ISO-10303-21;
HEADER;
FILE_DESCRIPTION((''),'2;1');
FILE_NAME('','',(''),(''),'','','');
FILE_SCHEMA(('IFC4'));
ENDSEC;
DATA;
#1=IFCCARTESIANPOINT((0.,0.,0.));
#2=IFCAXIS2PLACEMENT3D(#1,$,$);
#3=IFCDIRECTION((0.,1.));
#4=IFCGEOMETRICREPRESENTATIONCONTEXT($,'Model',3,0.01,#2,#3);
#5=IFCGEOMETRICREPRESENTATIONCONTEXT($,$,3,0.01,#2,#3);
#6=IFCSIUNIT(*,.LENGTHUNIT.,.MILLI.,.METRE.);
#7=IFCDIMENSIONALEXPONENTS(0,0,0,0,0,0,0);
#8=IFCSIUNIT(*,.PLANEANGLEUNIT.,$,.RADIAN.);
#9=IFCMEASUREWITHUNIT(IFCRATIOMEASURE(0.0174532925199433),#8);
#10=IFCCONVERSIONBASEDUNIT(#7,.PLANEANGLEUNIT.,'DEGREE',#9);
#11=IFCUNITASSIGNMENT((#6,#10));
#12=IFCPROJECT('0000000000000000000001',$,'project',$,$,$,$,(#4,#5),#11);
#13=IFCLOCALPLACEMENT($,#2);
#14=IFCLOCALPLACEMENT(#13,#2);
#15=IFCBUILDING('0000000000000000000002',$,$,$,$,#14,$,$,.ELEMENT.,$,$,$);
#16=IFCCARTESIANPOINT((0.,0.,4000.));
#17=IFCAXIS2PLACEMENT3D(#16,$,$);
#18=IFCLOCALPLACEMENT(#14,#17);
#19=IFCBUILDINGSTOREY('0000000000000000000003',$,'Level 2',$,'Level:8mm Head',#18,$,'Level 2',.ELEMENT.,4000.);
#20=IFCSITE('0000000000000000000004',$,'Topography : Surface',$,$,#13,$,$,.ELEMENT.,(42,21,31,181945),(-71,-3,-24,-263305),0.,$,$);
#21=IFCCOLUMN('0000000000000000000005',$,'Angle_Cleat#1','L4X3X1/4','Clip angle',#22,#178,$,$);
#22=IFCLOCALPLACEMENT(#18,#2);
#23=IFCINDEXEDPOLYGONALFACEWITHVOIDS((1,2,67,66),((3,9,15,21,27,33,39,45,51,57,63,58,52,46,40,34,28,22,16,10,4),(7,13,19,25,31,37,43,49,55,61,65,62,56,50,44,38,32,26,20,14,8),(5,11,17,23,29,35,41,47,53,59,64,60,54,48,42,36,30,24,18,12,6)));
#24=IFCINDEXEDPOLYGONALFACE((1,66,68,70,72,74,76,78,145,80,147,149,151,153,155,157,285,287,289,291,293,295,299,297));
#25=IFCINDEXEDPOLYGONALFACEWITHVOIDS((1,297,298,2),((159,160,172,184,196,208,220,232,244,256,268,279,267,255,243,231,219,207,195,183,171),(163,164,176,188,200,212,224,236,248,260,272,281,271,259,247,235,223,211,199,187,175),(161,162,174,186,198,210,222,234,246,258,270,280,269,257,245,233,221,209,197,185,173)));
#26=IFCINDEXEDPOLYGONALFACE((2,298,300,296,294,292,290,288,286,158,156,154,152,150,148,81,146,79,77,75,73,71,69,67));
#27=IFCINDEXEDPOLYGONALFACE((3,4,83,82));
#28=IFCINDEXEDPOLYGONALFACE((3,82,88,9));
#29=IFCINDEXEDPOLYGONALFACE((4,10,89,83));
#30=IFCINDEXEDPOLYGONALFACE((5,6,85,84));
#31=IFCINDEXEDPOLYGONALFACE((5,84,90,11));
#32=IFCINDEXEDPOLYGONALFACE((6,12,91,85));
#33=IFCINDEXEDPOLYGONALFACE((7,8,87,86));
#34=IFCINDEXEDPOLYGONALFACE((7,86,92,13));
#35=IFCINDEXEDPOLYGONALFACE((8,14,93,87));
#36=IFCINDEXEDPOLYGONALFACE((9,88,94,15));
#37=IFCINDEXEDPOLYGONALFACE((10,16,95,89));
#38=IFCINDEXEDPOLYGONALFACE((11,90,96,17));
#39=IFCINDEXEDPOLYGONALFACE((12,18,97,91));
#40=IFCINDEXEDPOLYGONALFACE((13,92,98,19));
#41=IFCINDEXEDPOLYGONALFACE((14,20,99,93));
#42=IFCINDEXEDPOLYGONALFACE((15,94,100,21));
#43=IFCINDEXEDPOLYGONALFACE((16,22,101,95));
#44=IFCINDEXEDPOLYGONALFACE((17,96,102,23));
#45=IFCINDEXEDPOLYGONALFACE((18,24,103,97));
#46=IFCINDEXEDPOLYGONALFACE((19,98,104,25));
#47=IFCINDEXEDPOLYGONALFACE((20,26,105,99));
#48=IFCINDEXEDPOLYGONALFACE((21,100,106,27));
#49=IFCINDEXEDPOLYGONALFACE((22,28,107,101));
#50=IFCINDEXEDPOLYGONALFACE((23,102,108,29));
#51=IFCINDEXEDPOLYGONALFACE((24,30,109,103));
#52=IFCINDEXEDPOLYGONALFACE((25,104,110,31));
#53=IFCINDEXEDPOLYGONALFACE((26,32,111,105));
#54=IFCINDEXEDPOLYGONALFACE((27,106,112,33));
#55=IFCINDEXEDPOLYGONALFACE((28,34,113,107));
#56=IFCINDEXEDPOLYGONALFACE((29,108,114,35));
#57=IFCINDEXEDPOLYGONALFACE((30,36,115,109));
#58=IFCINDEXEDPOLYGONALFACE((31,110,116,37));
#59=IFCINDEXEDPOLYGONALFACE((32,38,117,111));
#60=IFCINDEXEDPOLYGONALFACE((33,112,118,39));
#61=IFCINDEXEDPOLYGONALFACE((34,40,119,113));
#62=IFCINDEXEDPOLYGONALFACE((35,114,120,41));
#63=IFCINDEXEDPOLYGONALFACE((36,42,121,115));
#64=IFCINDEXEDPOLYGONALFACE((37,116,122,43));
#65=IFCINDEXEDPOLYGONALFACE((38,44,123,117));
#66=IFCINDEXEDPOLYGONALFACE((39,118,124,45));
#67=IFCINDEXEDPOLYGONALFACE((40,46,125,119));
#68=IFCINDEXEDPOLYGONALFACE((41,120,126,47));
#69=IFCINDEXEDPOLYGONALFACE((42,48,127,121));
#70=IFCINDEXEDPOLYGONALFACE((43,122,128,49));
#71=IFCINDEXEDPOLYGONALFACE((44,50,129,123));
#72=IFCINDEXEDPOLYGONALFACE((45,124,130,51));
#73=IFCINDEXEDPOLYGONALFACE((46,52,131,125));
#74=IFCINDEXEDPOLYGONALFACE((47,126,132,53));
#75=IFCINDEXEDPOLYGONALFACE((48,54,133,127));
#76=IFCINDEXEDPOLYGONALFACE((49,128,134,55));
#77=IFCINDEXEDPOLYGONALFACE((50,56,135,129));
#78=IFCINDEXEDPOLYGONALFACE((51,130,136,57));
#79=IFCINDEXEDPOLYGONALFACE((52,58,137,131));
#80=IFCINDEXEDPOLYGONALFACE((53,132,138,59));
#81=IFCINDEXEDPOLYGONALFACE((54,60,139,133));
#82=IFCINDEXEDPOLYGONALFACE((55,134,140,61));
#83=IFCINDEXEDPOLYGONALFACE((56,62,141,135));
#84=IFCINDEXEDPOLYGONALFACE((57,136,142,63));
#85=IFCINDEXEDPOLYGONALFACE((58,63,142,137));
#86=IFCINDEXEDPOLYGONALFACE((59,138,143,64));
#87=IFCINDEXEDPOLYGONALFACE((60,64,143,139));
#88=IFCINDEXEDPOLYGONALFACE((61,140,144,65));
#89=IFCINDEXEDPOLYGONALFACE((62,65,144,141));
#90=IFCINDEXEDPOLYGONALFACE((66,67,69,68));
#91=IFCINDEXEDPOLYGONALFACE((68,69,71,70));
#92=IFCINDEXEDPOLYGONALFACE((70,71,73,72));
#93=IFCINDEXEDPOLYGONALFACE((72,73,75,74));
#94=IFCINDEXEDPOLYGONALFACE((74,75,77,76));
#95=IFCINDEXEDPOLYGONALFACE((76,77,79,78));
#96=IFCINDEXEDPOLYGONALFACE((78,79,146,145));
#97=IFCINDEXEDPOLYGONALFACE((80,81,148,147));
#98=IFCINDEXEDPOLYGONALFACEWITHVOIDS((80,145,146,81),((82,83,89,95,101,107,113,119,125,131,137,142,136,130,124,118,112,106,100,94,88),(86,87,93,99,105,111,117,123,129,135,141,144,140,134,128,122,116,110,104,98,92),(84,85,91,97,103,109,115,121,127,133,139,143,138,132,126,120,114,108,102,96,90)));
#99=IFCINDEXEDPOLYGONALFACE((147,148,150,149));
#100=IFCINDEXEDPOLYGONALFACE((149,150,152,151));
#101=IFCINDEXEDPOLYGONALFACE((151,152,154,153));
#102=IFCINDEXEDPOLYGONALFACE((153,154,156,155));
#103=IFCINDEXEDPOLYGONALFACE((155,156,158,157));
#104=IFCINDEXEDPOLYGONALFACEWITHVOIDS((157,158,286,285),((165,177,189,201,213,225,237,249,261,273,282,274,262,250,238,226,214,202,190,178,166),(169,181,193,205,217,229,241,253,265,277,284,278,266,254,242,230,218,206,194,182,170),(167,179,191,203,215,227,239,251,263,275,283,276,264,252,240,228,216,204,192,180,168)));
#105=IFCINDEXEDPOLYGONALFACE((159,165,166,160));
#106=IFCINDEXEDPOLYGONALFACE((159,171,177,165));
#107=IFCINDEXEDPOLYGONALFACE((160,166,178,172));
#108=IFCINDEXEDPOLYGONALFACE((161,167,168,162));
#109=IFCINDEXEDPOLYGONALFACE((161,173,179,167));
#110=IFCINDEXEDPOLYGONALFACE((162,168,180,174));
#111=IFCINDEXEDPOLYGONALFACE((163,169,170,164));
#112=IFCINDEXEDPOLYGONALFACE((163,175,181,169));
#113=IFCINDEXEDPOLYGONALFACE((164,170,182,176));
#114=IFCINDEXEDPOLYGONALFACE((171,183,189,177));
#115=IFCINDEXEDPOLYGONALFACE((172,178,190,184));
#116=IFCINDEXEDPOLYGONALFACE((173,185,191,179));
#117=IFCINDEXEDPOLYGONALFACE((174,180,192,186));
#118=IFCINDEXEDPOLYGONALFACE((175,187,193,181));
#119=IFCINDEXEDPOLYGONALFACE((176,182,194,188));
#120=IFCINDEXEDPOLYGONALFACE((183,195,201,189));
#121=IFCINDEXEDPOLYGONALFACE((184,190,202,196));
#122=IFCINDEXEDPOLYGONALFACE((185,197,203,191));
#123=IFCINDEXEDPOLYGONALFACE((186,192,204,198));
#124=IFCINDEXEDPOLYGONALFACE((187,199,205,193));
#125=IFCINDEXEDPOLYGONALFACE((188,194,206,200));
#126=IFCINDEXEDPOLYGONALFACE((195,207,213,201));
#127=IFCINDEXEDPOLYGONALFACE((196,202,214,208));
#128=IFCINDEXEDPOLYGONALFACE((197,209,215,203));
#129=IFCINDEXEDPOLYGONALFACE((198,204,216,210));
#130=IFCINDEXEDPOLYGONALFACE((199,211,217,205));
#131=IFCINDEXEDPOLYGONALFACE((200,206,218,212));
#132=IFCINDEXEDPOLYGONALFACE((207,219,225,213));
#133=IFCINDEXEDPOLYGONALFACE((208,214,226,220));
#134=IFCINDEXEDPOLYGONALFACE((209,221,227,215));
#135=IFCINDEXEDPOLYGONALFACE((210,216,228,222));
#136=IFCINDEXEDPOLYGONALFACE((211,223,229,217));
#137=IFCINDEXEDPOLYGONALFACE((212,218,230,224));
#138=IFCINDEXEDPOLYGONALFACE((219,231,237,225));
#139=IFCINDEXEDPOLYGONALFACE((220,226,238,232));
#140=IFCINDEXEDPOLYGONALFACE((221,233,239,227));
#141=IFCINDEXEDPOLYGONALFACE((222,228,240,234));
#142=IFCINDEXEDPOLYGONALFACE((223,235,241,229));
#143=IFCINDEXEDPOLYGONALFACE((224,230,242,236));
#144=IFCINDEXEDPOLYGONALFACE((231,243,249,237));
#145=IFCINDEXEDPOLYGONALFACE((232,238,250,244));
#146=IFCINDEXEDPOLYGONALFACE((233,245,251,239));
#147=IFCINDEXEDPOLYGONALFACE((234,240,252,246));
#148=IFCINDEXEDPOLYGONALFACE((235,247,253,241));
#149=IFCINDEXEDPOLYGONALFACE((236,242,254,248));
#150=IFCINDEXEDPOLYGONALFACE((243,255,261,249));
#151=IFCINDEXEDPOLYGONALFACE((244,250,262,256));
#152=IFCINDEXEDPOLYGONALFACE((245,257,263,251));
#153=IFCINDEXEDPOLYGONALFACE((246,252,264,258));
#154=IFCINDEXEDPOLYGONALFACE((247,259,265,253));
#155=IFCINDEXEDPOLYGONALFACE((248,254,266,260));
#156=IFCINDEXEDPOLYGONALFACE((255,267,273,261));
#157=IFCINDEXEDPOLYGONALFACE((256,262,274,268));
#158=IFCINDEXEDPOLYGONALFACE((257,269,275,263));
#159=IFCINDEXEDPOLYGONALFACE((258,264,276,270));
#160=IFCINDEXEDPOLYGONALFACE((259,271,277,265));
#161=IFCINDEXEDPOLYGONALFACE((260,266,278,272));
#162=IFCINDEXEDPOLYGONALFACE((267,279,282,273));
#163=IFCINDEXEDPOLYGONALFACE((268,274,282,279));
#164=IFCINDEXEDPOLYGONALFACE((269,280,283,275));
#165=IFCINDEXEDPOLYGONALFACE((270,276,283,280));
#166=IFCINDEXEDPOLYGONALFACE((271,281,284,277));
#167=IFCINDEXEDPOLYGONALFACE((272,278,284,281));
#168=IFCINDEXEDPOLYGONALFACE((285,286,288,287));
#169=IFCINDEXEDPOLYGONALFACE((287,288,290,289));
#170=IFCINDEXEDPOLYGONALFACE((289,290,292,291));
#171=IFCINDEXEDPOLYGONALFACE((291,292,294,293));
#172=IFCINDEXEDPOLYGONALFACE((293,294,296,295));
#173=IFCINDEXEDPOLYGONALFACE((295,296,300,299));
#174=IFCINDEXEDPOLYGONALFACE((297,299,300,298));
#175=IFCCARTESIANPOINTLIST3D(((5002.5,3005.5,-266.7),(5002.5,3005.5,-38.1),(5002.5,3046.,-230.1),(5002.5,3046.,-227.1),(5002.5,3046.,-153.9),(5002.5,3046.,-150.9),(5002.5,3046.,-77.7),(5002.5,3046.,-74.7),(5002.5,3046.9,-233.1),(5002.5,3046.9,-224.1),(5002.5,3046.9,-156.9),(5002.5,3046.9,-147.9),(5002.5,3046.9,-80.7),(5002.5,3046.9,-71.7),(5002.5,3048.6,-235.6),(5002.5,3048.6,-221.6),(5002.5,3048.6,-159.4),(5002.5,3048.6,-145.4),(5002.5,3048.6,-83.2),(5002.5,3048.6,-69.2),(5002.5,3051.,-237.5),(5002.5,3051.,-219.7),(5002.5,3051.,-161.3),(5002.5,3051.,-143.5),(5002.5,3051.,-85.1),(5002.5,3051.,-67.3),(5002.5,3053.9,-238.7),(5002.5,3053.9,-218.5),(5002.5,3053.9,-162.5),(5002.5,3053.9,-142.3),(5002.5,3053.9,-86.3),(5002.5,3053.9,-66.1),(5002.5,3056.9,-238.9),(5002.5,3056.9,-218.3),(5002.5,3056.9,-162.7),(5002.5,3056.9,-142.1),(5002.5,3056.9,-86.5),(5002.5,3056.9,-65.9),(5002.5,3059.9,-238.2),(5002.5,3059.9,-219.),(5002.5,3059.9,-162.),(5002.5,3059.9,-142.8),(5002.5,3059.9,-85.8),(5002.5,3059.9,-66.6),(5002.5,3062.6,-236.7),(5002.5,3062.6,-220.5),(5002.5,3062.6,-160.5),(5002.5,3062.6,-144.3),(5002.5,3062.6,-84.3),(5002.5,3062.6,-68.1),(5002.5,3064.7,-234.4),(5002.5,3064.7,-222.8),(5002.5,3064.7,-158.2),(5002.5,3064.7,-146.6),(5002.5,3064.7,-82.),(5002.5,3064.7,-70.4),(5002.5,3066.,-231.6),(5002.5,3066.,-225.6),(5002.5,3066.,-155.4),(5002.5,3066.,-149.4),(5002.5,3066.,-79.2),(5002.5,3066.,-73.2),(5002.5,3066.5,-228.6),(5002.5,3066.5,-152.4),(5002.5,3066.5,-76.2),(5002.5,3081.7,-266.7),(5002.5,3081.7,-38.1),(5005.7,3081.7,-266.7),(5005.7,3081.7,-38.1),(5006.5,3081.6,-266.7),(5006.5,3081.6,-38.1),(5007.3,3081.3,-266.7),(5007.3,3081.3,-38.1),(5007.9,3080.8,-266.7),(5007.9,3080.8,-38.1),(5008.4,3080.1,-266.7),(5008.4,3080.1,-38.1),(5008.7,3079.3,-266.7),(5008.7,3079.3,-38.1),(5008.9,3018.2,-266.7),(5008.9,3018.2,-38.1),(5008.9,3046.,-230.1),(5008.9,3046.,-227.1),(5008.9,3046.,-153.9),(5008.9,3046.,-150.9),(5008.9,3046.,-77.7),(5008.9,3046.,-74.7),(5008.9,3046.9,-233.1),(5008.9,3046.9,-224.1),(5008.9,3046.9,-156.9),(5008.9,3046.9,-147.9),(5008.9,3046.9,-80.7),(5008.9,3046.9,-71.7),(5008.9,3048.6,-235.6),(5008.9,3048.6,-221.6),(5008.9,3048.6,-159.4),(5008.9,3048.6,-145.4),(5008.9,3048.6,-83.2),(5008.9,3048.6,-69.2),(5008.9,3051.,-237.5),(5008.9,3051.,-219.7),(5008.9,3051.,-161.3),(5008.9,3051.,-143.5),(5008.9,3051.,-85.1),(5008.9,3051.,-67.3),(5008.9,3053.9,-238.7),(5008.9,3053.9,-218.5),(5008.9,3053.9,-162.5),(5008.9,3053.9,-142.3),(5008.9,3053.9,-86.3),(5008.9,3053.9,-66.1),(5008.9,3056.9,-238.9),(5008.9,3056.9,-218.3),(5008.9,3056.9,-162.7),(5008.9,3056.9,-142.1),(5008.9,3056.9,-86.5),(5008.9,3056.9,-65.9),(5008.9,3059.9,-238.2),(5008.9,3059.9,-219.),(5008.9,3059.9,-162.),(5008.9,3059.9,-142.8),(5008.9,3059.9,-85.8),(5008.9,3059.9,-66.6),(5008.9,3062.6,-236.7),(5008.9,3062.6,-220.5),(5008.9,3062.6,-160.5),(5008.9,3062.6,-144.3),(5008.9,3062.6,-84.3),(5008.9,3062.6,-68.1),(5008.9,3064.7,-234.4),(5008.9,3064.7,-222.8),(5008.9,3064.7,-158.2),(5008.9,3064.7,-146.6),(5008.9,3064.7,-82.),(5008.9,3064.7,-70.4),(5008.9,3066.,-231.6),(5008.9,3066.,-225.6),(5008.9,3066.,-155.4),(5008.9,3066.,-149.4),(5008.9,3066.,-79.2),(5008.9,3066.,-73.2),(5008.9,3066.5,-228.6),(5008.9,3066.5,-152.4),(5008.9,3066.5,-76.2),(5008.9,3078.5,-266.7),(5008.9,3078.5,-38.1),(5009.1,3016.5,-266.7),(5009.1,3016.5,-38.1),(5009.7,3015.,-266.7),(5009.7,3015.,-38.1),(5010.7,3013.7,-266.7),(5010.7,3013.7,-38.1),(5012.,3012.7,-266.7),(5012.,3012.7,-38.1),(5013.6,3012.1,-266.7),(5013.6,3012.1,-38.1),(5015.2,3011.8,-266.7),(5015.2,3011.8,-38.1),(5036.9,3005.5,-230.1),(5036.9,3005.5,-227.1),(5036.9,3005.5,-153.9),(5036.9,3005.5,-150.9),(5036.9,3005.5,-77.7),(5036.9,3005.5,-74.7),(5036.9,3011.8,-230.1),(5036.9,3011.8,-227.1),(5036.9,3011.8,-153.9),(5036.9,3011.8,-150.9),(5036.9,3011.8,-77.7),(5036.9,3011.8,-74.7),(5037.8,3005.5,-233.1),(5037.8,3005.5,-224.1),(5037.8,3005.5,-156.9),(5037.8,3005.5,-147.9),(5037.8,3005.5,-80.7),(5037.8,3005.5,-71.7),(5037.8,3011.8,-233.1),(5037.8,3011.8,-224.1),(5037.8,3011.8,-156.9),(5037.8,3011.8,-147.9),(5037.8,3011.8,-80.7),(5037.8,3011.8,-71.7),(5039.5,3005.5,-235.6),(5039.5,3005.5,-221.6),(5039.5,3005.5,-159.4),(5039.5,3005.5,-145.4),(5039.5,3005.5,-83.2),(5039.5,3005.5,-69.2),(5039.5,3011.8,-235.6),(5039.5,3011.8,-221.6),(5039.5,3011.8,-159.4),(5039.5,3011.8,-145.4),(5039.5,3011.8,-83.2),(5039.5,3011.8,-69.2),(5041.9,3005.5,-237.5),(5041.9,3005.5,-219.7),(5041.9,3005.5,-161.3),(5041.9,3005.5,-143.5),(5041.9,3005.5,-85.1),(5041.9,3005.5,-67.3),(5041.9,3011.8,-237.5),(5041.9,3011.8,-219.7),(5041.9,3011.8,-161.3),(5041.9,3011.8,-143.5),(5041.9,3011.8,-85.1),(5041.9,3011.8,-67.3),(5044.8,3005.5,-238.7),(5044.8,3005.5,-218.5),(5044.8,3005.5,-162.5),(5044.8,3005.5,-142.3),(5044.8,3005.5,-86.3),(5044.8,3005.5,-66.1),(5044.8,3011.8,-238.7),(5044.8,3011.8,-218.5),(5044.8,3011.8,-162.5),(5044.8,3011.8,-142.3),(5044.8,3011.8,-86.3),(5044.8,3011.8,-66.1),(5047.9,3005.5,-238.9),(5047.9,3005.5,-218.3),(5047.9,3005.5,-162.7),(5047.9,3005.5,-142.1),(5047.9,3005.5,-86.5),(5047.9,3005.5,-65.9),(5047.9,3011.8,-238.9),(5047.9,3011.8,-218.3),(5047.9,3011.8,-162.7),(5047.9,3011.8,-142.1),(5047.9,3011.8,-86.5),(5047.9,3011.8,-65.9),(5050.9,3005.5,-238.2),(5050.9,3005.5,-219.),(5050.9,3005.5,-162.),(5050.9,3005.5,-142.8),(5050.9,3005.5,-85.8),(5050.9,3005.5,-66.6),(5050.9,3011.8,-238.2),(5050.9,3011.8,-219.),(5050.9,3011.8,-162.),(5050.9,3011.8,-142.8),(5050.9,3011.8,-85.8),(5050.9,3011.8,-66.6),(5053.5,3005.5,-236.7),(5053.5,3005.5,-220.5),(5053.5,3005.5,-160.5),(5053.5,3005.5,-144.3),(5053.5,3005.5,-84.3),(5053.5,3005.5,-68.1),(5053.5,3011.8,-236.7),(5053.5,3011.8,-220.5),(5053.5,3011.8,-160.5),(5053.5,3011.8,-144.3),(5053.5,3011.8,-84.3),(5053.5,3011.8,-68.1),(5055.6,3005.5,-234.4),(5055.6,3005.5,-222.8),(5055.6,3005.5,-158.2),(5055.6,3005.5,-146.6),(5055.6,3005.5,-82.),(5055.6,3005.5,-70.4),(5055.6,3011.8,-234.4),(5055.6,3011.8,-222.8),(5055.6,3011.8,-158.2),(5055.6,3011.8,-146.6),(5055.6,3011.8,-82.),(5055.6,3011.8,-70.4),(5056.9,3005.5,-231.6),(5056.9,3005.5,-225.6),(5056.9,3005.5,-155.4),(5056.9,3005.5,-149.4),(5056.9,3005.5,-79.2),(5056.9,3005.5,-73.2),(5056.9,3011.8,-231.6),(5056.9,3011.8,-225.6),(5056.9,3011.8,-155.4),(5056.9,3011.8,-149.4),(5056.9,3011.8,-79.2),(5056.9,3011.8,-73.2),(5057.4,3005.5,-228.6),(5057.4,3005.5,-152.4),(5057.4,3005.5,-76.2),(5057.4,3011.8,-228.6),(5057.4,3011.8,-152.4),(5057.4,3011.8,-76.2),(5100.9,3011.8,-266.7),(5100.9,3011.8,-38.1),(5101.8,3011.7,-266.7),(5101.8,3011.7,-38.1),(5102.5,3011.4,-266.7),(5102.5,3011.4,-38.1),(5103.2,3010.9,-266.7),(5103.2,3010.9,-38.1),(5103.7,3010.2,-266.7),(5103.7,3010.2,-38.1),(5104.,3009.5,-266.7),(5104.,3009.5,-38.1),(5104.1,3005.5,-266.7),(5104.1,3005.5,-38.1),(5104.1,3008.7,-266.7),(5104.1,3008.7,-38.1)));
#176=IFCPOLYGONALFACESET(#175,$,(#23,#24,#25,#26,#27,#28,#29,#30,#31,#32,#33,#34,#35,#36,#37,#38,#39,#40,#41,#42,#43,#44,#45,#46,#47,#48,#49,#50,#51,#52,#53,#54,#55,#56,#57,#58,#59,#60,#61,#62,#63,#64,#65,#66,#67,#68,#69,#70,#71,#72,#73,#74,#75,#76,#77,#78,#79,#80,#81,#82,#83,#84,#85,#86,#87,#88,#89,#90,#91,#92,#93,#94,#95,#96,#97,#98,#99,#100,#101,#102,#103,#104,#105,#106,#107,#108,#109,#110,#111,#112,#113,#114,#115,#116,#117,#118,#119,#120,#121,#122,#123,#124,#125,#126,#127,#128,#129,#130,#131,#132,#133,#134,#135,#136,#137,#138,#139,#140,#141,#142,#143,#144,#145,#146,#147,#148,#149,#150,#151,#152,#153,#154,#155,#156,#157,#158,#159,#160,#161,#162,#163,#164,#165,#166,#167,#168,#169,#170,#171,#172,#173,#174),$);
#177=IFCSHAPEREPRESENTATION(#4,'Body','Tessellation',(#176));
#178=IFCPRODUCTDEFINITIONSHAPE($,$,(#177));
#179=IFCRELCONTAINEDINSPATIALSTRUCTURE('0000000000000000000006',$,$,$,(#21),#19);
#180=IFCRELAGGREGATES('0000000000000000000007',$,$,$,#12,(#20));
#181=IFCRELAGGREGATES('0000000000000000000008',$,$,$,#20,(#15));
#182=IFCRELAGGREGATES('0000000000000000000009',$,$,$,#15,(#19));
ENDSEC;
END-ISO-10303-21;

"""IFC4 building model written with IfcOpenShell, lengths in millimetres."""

from ifc_helpers import new_model, entity, si_unit, converted_unit, direction, frame, frame_2d, origin, origin_2d_with_axis, place, context, project, spatial, circle, l_section, extrude, element, save


model = new_model("IFC4")

# Units and contexts
model_context = context("Model", 3, precision=0.01, world=origin(), true_north=direction((0.0, 1.0)))
context_of_model = context(None, 3, precision=0.01, world=origin(), true_north=direction((0.0, 1.0)))
ifc_project = project(units=[si_unit("LENGTHUNIT", "METRE", prefix="MILLI"), converted_unit("PLANEANGLEUNIT", "DEGREE", entity("IfcRatioMeasure", 0.0174532925199433), si_unit("PLANEANGLEUNIT", "RADIAN"), dimensions=[0, 0, 0, 0, 0, 0, 0])], contexts=[model_context, context_of_model])

# Site, building, storey
site_placement = place(None, origin())
site = spatial("IfcSite", under=ifc_project, at=site_placement, Name="Topography : Surface", CompositionType="ELEMENT", RefLatitude=(42, 21, 31, 181945), RefLongitude=(-71, -3, -24, -263305), RefElevation=0.0)
building_placement = place(site_placement, origin())
building = spatial("IfcBuilding", under=site, at=building_placement, CompositionType="ELEMENT")
storey_placement = place(building_placement, frame((0.0, 0.0, 4000.0)))
storey = spatial("IfcBuildingStorey", under=building, at=storey_placement, Name="Level 2", ObjectType="Level:8mm Head", LongName="Level 2", CompositionType="ELEMENT", Elevation=4000.0)

# Column, openings
column_1_placement = place(storey_placement, frame((5033.6, 3023.8, -266.7), z_axis=(0.0, 0.0, -1.0), x_axis=(0.0, 1.0, 0.0)))
column_1 = element("IfcColumn", 1, at=column_1_placement, inside=storey, Name="Angle_Cleat#1", Description="L4X3X1/4", ObjectType="Clip angle", context=model_context, shape_type="SweptSolid", body=[
    extrude(l_section(Depth=101.6, Width=76.2, Thickness=6.3, FilletRadius=6.3, EdgeRadius=3.2, at=frame_2d((19.8, 19.7))), origin(), (0.0, 0.0, -1.0), 228.6),
])
opening_1_placement = place(column_1_placement, frame((32.4, -31.5, -114.3), z_axis=(0.0, 1.0, 0.0), x_axis=(1.0, 0.0, 0.0)))
element("IfcOpeningElement", 2, at=opening_1_placement, cuts=column_1, ObjectType="Opening", context=model_context, shape_type="SweptSolid", body=[
    extrude(circle(Radius=10.3, at=origin_2d_with_axis()), origin(), (0.0, 0.0, 1.0), 7.3),
])
opening_2_placement = place(column_1_placement, frame((32.4, -31.5, -114.3), z_axis=(0.0, 1.0, 0.0), x_axis=(1.0, 0.0, 0.0)))
element("IfcOpeningElement", 3, at=opening_2_placement, cuts=column_1, ObjectType="Opening", context=model_context, shape_type="SweptSolid", body=[
    extrude(circle(Radius=10.3, at=frame_2d((0.0, 76.2), x_axis=(1.0, 0.0))), origin(), (0.0, 0.0, 1.0), 7.3),
])
opening_3_placement = place(column_1_placement, frame((32.4, -31.5, -114.3), z_axis=(0.0, 1.0, 0.0), x_axis=(1.0, 0.0, 0.0)))
element("IfcOpeningElement", 4, at=opening_3_placement, cuts=column_1, ObjectType="Opening", context=model_context, shape_type="SweptSolid", body=[
    extrude(circle(Radius=10.3, at=frame_2d((0.0, -76.2), x_axis=(1.0, 0.0))), origin(), (0.0, 0.0, 1.0), 7.3),
])
opening_4_placement = place(column_1_placement, frame((-18.9, 13.5, -114.3), z_axis=(1.0, 0.0, 0.0), x_axis=(0.0, 1.0, 0.0)))
element("IfcOpeningElement", 5, at=opening_4_placement, cuts=column_1, ObjectType="Opening", context=model_context, shape_type="SweptSolid", body=[
    extrude(circle(Radius=10.3, at=origin_2d_with_axis()), origin(), (0.0, 0.0, 1.0), 7.3),
])
opening_5_placement = place(column_1_placement, frame((-18.9, 13.5, -114.3), z_axis=(1.0, 0.0, 0.0), x_axis=(0.0, 1.0, 0.0)))
element("IfcOpeningElement", 6, at=opening_5_placement, cuts=column_1, ObjectType="Opening", context=model_context, shape_type="SweptSolid", body=[
    extrude(circle(Radius=10.3, at=frame_2d((0.0, 76.2), x_axis=(1.0, 0.0))), origin(), (0.0, 0.0, 1.0), 7.3),
])
opening_6_placement = place(column_1_placement, frame((-18.9, 13.5, -114.3), z_axis=(1.0, 0.0, 0.0), x_axis=(0.0, 1.0, 0.0)))
element("IfcOpeningElement", 7, at=opening_6_placement, cuts=column_1, ObjectType="Opening", context=model_context, shape_type="SweptSolid", body=[
    extrude(circle(Radius=10.3, at=frame_2d((0.0, -76.2), x_axis=(1.0, 0.0))), origin(), (0.0, 0.0, 1.0), 7.3),
])

save(model, "model.ifc")
